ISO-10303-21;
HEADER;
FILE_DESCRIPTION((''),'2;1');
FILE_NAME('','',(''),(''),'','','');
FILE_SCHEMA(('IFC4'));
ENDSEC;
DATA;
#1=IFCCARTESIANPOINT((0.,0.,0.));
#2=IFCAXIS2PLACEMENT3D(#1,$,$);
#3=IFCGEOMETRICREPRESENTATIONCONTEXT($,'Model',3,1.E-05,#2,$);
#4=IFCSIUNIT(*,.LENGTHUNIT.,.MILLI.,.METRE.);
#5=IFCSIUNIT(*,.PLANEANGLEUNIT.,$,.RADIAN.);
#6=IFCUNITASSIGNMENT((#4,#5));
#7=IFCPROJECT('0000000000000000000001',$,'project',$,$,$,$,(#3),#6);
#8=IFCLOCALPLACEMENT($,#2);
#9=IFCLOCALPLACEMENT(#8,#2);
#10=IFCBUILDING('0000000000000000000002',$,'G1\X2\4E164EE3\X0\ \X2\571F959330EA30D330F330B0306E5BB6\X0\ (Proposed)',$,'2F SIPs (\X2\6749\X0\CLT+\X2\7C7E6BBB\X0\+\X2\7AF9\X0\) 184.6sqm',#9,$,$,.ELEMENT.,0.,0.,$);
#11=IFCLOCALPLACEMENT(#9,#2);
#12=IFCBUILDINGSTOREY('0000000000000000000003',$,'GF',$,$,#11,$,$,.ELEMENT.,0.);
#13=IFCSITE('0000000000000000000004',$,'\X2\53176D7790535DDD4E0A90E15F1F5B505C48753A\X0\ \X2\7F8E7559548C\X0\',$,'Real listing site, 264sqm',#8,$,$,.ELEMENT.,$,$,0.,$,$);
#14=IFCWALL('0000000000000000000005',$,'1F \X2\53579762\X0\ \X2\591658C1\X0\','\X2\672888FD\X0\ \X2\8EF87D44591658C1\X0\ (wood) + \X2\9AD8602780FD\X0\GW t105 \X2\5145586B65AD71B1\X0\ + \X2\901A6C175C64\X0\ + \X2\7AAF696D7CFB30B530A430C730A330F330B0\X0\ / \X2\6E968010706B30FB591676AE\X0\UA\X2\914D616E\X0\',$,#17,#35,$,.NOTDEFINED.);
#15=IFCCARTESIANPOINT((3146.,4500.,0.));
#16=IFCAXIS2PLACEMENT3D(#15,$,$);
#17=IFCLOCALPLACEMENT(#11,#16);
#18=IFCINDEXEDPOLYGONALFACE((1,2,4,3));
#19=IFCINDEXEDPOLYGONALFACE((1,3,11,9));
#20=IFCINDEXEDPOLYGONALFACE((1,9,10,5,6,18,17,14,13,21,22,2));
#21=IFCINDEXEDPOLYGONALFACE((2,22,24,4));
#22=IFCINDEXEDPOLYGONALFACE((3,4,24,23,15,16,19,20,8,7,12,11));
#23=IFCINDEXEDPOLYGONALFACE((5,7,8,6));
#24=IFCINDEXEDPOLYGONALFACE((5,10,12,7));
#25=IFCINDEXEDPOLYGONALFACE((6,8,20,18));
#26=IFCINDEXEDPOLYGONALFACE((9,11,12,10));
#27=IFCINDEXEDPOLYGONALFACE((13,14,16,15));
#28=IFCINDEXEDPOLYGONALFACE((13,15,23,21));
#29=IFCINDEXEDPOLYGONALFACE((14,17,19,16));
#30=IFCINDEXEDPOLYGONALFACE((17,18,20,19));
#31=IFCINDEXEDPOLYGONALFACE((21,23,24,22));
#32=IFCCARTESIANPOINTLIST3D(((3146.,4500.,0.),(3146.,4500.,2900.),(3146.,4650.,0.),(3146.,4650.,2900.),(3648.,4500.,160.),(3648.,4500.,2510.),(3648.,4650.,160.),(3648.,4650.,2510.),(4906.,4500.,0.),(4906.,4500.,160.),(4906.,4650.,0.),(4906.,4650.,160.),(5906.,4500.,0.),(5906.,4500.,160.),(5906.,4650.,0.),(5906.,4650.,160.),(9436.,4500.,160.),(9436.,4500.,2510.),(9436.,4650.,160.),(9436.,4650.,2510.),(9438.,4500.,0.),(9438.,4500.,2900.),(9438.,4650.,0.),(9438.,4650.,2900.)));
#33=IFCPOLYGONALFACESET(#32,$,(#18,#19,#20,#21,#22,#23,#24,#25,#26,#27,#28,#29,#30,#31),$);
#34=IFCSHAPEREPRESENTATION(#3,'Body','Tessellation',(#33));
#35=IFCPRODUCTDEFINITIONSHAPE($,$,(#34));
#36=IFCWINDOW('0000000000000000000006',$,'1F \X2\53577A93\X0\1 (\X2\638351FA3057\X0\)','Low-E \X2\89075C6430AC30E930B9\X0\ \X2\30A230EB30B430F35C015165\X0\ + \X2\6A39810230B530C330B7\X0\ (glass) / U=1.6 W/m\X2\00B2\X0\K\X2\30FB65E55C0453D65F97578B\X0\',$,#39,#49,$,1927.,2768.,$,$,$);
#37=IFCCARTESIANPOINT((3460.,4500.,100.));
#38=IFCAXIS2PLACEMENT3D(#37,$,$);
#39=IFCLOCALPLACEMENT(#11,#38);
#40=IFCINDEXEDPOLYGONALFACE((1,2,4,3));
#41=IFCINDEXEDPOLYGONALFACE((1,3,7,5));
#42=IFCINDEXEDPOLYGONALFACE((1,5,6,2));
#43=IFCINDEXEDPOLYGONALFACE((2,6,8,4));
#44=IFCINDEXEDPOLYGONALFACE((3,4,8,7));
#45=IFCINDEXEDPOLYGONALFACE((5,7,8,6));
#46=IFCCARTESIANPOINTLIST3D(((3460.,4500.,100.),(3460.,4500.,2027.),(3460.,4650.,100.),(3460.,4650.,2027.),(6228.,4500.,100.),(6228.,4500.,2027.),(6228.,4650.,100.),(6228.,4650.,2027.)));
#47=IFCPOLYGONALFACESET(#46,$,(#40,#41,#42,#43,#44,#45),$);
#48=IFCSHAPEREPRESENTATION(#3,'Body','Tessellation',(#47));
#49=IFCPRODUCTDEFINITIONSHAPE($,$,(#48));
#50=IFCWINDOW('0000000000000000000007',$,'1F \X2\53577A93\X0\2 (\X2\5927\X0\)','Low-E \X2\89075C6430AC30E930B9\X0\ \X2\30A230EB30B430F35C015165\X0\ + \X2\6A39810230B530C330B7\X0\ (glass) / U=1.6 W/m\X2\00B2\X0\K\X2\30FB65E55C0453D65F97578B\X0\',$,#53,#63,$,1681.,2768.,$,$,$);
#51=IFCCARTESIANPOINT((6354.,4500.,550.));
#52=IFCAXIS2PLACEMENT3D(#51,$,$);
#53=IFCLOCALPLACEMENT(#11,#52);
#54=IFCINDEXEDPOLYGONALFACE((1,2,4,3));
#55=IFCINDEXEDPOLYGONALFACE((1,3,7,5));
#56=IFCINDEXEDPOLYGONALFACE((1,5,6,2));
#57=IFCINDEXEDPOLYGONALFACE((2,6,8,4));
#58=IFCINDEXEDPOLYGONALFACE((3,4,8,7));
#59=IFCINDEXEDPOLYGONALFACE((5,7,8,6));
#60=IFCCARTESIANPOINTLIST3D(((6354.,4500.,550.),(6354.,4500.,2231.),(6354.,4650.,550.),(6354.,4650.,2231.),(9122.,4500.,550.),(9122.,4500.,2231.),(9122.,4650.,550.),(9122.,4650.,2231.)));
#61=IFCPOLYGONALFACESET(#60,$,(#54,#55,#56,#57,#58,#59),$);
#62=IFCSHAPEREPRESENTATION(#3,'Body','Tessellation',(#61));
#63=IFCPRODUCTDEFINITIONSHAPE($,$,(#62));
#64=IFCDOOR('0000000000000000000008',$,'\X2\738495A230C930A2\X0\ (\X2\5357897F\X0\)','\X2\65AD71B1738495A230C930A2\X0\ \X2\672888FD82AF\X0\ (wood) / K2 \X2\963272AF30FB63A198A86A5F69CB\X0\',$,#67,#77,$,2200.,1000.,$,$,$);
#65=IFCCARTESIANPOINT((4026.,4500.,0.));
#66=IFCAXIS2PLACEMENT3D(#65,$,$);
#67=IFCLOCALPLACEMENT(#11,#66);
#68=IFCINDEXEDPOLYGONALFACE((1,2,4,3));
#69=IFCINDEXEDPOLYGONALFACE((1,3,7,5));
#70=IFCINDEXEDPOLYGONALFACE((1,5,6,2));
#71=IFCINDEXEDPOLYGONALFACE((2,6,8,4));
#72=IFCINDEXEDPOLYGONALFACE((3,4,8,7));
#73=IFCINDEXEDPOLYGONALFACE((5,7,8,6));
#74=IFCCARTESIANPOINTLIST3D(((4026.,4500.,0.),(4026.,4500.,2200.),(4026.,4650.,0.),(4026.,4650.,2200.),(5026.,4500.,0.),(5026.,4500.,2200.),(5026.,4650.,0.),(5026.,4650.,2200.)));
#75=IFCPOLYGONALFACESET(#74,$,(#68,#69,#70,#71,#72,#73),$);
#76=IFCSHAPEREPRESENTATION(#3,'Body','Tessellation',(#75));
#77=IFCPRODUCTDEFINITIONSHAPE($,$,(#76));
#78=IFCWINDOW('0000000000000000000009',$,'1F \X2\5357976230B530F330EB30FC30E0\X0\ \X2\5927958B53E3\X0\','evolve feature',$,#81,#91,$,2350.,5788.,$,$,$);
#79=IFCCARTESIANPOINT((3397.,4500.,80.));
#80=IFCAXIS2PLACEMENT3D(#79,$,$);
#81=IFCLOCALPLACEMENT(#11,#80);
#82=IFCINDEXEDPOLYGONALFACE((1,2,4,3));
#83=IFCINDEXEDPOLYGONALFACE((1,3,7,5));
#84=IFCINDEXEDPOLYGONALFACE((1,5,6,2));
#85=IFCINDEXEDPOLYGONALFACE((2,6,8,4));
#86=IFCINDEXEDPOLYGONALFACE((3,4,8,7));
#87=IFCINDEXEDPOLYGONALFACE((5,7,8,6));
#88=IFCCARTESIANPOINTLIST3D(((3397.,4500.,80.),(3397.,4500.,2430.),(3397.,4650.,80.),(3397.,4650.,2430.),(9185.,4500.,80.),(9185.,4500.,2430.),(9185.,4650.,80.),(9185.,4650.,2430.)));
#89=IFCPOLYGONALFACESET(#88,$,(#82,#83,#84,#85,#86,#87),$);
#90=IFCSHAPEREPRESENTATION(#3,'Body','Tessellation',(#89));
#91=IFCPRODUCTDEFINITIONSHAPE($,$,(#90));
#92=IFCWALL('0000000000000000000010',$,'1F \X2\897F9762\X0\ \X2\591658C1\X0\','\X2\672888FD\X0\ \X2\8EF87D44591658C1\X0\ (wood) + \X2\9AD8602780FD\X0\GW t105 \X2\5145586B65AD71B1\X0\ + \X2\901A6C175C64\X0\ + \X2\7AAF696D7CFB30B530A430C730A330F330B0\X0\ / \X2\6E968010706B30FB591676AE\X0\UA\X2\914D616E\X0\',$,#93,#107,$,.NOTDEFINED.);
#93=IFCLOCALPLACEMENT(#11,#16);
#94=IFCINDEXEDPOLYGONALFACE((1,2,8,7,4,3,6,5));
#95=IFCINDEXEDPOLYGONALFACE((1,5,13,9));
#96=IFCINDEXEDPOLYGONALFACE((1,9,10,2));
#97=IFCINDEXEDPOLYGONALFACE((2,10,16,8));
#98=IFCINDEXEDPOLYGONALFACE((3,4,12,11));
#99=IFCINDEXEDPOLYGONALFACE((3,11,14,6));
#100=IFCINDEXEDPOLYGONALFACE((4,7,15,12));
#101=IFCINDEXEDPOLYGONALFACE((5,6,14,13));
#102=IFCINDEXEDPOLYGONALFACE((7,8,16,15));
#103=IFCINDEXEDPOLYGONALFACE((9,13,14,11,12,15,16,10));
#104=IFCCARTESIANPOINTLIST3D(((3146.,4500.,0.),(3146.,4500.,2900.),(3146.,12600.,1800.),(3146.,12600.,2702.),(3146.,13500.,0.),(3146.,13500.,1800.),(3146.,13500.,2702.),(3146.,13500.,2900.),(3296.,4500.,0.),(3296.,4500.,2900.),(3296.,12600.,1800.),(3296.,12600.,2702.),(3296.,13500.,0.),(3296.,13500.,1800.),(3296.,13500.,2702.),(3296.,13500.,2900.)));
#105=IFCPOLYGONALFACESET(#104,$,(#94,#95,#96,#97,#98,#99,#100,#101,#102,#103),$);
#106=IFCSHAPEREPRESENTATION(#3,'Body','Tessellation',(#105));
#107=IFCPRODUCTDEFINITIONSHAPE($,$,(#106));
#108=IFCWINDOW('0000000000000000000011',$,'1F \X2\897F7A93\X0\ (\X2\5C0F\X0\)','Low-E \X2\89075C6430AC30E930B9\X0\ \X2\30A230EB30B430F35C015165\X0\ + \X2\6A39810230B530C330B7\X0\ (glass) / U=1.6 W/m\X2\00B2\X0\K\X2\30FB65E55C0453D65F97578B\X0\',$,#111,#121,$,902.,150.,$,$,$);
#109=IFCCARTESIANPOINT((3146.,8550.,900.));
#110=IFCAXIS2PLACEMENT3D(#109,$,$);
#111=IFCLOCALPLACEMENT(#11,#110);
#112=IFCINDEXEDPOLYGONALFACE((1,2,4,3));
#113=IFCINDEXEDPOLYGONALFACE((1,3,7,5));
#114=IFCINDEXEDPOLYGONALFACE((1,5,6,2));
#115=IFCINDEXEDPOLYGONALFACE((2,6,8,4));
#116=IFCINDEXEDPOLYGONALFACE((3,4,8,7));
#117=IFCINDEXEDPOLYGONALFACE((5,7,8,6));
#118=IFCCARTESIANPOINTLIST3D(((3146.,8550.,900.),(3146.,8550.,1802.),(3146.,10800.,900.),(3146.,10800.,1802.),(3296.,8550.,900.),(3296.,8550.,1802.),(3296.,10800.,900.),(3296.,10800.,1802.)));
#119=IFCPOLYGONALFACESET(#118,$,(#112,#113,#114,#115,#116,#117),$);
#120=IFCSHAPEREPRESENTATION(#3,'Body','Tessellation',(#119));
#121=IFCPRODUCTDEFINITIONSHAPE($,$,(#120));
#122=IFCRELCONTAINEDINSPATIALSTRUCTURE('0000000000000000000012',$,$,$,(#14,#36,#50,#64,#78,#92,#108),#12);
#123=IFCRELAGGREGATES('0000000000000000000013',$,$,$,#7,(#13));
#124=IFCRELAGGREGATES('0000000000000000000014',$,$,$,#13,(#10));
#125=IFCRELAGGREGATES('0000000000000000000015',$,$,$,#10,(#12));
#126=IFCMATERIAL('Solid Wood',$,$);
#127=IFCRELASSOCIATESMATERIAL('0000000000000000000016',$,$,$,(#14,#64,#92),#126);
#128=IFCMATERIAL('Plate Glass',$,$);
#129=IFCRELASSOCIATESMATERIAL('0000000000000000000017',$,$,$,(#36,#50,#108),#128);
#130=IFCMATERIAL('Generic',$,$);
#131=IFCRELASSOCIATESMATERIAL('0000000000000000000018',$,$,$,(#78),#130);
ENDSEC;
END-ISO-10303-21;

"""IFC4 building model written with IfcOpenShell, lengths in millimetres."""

from ifc_helpers import new_model, si_unit, frame, frame_2d, origin, place, context, project, spatial, rectangle, extrude, material, element, fill, save


model = new_model("IFC4")

# Units and contexts
model_context = context("Model", 3, precision=1e-05, world=origin())
ifc_project = project(units=[si_unit("LENGTHUNIT", "METRE", prefix="MILLI"), si_unit("PLANEANGLEUNIT", "RADIAN")], contexts=[model_context])

# Site, building, storey
site_placement = place(None, origin())
site = spatial("IfcSite", under=ifc_project, at=site_placement, Name="北海道川上郡弟子屈町 美留和", ObjectType="Real listing site, 264sqm", CompositionType="ELEMENT", RefElevation=0.0)
building_placement = place(site_placement, origin())
building = spatial("IfcBuilding", under=site, at=building_placement, Name="G1世代 土間リビングの家 (Proposed)", ObjectType="2F SIPs (杉CLT+籾殻+竹) 184.6sqm", CompositionType="ELEMENT", ElevationOfRefHeight=0.0, ElevationOfTerrain=0.0)
storey_placement = place(building_placement, origin())
storey = spatial("IfcBuildingStorey", under=building, at=storey_placement, Name="GF", CompositionType="ELEMENT", Elevation=0.0)

# Shared definitions
ifc_material_1 = material(Name="Solid Wood")
ifc_material_2 = material(Name="Generic")

# Wall, openings, windows, door
wall_1_placement = place(storey_placement, frame((3146.0, 4500.0, 0.0)))
wall_1 = element("IfcWall", 1, at=wall_1_placement, inside=storey, material=ifc_material_1, Name="1F 南面 外壁", Description="木製 軸組外壁 (wood) + 高性能GW t105 充填断熱 + 通気層 + 窯業系サイディング / 準耐火・外皮UA配慮", PredefinedType="NOTDEFINED", context=model_context, shape_type="SweptSolid", body=[
    extrude(rectangle(XDim=6292.0, YDim=150.0, at=frame_2d((3146.0, 75.0))), frame((3146.0, 4500.0, 0.0)), (0.0, 0.0, 1.0), 2900.0),
])
opening_1_placement = place(storey_placement, frame((3460.0, 4500.0, 100.0)))
opening_1 = element("IfcOpeningElement", 2, at=opening_1_placement, cuts=wall_1, PredefinedType="NOTDEFINED", context=model_context, shape_type="SweptSolid", body=[
    extrude(rectangle(XDim=2768.0, YDim=150.0, at=frame_2d((1384.0, 75.0))), frame((3460.0, 4500.0, 100.0)), (0.0, 0.0, 1.0), 1927.0),
])
opening_2_placement = place(storey_placement, frame((6354.0, 4500.0, 550.0)))
opening_2 = element("IfcOpeningElement", 3, at=opening_2_placement, cuts=wall_1, PredefinedType="NOTDEFINED", context=model_context, shape_type="SweptSolid", body=[
    extrude(rectangle(XDim=2768.0, YDim=150.0, at=frame_2d((1384.0, 75.0))), frame((6354.0, 4500.0, 550.0)), (0.0, 0.0, 1.0), 1681.0),
])
opening_3_placement = place(storey_placement, frame((4026.0, 4500.0, 0.0)))
opening_3 = element("IfcOpeningElement", 4, at=opening_3_placement, cuts=wall_1, PredefinedType="NOTDEFINED", context=model_context, shape_type="SweptSolid", body=[
    extrude(rectangle(XDim=1000.0, YDim=150.0, at=frame_2d((500.0, 75.0))), frame((4026.0, 4500.0, 0.0)), (0.0, 0.0, 1.0), 2200.0),
])
opening_4_placement = place(storey_placement, frame((3397.0, 4500.0, 80.0)))
opening_4 = element("IfcOpeningElement", 5, at=opening_4_placement, cuts=wall_1, PredefinedType="NOTDEFINED", context=model_context, shape_type="SweptSolid", body=[
    extrude(rectangle(XDim=5788.0, YDim=150.0, at=frame_2d((2894.0, 75.0))), frame((3397.0, 4500.0, 80.0)), (0.0, 0.0, 1.0), 2350.0),
])
ifc_material_3 = material(Name="Plate Glass")
window_1_placement = place(storey_placement, frame((3460.0, 4500.0, 100.0)))
window_1 = element("IfcWindow", 6, at=window_1_placement, inside=storey, material=ifc_material_3, Name="1F 南窓1 (掃出し)", Description="Low-E 複層ガラス アルゴン封入 + 樹脂サッシ (glass) / U=1.6 W/m²K・日射取得型", OverallHeight=1927.0, OverallWidth=2768.0, context=model_context, shape_type="SweptSolid", body=[
    extrude(rectangle(XDim=2768.0, YDim=150.0, at=frame_2d((1384.0, 75.0))), frame((3460.0, 4500.0, 100.0)), (0.0, 0.0, 1.0), 1927.0),
])
fill(opening_1, window_1)
window_2_placement = place(storey_placement, frame((6354.0, 4500.0, 550.0)))
window_2 = element("IfcWindow", 7, at=window_2_placement, inside=storey, material=ifc_material_3, Name="1F 南窓2 (大)", Description="Low-E 複層ガラス アルゴン封入 + 樹脂サッシ (glass) / U=1.6 W/m²K・日射取得型", OverallHeight=1681.0, OverallWidth=2768.0, context=model_context, shape_type="SweptSolid", body=[
    extrude(rectangle(XDim=2768.0, YDim=150.0, at=frame_2d((1384.0, 75.0))), frame((6354.0, 4500.0, 550.0)), (0.0, 0.0, 1.0), 1681.0),
])
fill(opening_2, window_2)
door_placement = place(storey_placement, frame((4026.0, 4500.0, 0.0)))
door = element("IfcDoor", 8, at=door_placement, inside=storey, material=ifc_material_1, Name="玄関ドア (南西)", Description="断熱玄関ドア 木製芯 (wood) / K2 防犯・採風機構", OverallHeight=2200.0, OverallWidth=1000.0, context=model_context, shape_type="SweptSolid", body=[
    extrude(rectangle(XDim=1000.0, YDim=150.0, at=frame_2d((500.0, 75.0))), frame((4026.0, 4500.0, 0.0)), (0.0, 0.0, 1.0), 2200.0),
])
fill(opening_3, door)
window_3_placement = place(storey_placement, frame((3397.0, 4500.0, 80.0)))
window_3 = element("IfcWindow", 9, at=window_3_placement, inside=storey, material=ifc_material_2, Name="1F 南面サンルーム 大開口", Description="evolve feature", OverallHeight=2350.0, OverallWidth=5788.0, context=model_context, shape_type="SweptSolid", body=[
    extrude(rectangle(XDim=5788.0, YDim=150.0, at=frame_2d((2894.0, 75.0))), frame((3397.0, 4500.0, 80.0)), (0.0, 0.0, 1.0), 2350.0),
])
fill(opening_4, window_3)

# Wall, opening, window
wall_2_placement = place(storey_placement, frame((3146.0, 4500.0, 0.0)))
wall_2 = element("IfcWall", 10, at=wall_2_placement, inside=storey, material=ifc_material_1, Name="1F 西面 外壁", Description="木製 軸組外壁 (wood) + 高性能GW t105 充填断熱 + 通気層 + 窯業系サイディング / 準耐火・外皮UA配慮", PredefinedType="NOTDEFINED", context=model_context, shape_type="SweptSolid", body=[
    extrude(rectangle(XDim=150.0, YDim=9000.0, at=frame_2d((75.0, 4500.0))), frame((3146.0, 4500.0, 0.0)), (0.0, 0.0, 1.0), 2900.0),
])
opening_5_placement = place(storey_placement, frame((3146.0, 8550.0, 900.0)))
opening_5 = element("IfcOpeningElement", 11, at=opening_5_placement, cuts=wall_2, PredefinedType="NOTDEFINED", context=model_context, shape_type="SweptSolid", body=[
    extrude(rectangle(XDim=150.0, YDim=2250.0, at=frame_2d((75.0, 1125.0))), frame((3146.0, 8550.0, 900.0)), (0.0, 0.0, 1.0), 902.0),
])
window_4_placement = place(storey_placement, frame((3146.0, 8550.0, 900.0)))
window_4 = element("IfcWindow", 12, at=window_4_placement, inside=storey, material=ifc_material_3, Name="1F 西窓 (小)", Description="Low-E 複層ガラス アルゴン封入 + 樹脂サッシ (glass) / U=1.6 W/m²K・日射取得型", OverallHeight=902.0, OverallWidth=150.0, context=model_context, shape_type="SweptSolid", body=[
    extrude(rectangle(XDim=150.0, YDim=2250.0, at=frame_2d((75.0, 1125.0))), frame((3146.0, 8550.0, 900.0)), (0.0, 0.0, 1.0), 902.0),
])
fill(opening_5, window_4)

save(model, "model.ifc")
